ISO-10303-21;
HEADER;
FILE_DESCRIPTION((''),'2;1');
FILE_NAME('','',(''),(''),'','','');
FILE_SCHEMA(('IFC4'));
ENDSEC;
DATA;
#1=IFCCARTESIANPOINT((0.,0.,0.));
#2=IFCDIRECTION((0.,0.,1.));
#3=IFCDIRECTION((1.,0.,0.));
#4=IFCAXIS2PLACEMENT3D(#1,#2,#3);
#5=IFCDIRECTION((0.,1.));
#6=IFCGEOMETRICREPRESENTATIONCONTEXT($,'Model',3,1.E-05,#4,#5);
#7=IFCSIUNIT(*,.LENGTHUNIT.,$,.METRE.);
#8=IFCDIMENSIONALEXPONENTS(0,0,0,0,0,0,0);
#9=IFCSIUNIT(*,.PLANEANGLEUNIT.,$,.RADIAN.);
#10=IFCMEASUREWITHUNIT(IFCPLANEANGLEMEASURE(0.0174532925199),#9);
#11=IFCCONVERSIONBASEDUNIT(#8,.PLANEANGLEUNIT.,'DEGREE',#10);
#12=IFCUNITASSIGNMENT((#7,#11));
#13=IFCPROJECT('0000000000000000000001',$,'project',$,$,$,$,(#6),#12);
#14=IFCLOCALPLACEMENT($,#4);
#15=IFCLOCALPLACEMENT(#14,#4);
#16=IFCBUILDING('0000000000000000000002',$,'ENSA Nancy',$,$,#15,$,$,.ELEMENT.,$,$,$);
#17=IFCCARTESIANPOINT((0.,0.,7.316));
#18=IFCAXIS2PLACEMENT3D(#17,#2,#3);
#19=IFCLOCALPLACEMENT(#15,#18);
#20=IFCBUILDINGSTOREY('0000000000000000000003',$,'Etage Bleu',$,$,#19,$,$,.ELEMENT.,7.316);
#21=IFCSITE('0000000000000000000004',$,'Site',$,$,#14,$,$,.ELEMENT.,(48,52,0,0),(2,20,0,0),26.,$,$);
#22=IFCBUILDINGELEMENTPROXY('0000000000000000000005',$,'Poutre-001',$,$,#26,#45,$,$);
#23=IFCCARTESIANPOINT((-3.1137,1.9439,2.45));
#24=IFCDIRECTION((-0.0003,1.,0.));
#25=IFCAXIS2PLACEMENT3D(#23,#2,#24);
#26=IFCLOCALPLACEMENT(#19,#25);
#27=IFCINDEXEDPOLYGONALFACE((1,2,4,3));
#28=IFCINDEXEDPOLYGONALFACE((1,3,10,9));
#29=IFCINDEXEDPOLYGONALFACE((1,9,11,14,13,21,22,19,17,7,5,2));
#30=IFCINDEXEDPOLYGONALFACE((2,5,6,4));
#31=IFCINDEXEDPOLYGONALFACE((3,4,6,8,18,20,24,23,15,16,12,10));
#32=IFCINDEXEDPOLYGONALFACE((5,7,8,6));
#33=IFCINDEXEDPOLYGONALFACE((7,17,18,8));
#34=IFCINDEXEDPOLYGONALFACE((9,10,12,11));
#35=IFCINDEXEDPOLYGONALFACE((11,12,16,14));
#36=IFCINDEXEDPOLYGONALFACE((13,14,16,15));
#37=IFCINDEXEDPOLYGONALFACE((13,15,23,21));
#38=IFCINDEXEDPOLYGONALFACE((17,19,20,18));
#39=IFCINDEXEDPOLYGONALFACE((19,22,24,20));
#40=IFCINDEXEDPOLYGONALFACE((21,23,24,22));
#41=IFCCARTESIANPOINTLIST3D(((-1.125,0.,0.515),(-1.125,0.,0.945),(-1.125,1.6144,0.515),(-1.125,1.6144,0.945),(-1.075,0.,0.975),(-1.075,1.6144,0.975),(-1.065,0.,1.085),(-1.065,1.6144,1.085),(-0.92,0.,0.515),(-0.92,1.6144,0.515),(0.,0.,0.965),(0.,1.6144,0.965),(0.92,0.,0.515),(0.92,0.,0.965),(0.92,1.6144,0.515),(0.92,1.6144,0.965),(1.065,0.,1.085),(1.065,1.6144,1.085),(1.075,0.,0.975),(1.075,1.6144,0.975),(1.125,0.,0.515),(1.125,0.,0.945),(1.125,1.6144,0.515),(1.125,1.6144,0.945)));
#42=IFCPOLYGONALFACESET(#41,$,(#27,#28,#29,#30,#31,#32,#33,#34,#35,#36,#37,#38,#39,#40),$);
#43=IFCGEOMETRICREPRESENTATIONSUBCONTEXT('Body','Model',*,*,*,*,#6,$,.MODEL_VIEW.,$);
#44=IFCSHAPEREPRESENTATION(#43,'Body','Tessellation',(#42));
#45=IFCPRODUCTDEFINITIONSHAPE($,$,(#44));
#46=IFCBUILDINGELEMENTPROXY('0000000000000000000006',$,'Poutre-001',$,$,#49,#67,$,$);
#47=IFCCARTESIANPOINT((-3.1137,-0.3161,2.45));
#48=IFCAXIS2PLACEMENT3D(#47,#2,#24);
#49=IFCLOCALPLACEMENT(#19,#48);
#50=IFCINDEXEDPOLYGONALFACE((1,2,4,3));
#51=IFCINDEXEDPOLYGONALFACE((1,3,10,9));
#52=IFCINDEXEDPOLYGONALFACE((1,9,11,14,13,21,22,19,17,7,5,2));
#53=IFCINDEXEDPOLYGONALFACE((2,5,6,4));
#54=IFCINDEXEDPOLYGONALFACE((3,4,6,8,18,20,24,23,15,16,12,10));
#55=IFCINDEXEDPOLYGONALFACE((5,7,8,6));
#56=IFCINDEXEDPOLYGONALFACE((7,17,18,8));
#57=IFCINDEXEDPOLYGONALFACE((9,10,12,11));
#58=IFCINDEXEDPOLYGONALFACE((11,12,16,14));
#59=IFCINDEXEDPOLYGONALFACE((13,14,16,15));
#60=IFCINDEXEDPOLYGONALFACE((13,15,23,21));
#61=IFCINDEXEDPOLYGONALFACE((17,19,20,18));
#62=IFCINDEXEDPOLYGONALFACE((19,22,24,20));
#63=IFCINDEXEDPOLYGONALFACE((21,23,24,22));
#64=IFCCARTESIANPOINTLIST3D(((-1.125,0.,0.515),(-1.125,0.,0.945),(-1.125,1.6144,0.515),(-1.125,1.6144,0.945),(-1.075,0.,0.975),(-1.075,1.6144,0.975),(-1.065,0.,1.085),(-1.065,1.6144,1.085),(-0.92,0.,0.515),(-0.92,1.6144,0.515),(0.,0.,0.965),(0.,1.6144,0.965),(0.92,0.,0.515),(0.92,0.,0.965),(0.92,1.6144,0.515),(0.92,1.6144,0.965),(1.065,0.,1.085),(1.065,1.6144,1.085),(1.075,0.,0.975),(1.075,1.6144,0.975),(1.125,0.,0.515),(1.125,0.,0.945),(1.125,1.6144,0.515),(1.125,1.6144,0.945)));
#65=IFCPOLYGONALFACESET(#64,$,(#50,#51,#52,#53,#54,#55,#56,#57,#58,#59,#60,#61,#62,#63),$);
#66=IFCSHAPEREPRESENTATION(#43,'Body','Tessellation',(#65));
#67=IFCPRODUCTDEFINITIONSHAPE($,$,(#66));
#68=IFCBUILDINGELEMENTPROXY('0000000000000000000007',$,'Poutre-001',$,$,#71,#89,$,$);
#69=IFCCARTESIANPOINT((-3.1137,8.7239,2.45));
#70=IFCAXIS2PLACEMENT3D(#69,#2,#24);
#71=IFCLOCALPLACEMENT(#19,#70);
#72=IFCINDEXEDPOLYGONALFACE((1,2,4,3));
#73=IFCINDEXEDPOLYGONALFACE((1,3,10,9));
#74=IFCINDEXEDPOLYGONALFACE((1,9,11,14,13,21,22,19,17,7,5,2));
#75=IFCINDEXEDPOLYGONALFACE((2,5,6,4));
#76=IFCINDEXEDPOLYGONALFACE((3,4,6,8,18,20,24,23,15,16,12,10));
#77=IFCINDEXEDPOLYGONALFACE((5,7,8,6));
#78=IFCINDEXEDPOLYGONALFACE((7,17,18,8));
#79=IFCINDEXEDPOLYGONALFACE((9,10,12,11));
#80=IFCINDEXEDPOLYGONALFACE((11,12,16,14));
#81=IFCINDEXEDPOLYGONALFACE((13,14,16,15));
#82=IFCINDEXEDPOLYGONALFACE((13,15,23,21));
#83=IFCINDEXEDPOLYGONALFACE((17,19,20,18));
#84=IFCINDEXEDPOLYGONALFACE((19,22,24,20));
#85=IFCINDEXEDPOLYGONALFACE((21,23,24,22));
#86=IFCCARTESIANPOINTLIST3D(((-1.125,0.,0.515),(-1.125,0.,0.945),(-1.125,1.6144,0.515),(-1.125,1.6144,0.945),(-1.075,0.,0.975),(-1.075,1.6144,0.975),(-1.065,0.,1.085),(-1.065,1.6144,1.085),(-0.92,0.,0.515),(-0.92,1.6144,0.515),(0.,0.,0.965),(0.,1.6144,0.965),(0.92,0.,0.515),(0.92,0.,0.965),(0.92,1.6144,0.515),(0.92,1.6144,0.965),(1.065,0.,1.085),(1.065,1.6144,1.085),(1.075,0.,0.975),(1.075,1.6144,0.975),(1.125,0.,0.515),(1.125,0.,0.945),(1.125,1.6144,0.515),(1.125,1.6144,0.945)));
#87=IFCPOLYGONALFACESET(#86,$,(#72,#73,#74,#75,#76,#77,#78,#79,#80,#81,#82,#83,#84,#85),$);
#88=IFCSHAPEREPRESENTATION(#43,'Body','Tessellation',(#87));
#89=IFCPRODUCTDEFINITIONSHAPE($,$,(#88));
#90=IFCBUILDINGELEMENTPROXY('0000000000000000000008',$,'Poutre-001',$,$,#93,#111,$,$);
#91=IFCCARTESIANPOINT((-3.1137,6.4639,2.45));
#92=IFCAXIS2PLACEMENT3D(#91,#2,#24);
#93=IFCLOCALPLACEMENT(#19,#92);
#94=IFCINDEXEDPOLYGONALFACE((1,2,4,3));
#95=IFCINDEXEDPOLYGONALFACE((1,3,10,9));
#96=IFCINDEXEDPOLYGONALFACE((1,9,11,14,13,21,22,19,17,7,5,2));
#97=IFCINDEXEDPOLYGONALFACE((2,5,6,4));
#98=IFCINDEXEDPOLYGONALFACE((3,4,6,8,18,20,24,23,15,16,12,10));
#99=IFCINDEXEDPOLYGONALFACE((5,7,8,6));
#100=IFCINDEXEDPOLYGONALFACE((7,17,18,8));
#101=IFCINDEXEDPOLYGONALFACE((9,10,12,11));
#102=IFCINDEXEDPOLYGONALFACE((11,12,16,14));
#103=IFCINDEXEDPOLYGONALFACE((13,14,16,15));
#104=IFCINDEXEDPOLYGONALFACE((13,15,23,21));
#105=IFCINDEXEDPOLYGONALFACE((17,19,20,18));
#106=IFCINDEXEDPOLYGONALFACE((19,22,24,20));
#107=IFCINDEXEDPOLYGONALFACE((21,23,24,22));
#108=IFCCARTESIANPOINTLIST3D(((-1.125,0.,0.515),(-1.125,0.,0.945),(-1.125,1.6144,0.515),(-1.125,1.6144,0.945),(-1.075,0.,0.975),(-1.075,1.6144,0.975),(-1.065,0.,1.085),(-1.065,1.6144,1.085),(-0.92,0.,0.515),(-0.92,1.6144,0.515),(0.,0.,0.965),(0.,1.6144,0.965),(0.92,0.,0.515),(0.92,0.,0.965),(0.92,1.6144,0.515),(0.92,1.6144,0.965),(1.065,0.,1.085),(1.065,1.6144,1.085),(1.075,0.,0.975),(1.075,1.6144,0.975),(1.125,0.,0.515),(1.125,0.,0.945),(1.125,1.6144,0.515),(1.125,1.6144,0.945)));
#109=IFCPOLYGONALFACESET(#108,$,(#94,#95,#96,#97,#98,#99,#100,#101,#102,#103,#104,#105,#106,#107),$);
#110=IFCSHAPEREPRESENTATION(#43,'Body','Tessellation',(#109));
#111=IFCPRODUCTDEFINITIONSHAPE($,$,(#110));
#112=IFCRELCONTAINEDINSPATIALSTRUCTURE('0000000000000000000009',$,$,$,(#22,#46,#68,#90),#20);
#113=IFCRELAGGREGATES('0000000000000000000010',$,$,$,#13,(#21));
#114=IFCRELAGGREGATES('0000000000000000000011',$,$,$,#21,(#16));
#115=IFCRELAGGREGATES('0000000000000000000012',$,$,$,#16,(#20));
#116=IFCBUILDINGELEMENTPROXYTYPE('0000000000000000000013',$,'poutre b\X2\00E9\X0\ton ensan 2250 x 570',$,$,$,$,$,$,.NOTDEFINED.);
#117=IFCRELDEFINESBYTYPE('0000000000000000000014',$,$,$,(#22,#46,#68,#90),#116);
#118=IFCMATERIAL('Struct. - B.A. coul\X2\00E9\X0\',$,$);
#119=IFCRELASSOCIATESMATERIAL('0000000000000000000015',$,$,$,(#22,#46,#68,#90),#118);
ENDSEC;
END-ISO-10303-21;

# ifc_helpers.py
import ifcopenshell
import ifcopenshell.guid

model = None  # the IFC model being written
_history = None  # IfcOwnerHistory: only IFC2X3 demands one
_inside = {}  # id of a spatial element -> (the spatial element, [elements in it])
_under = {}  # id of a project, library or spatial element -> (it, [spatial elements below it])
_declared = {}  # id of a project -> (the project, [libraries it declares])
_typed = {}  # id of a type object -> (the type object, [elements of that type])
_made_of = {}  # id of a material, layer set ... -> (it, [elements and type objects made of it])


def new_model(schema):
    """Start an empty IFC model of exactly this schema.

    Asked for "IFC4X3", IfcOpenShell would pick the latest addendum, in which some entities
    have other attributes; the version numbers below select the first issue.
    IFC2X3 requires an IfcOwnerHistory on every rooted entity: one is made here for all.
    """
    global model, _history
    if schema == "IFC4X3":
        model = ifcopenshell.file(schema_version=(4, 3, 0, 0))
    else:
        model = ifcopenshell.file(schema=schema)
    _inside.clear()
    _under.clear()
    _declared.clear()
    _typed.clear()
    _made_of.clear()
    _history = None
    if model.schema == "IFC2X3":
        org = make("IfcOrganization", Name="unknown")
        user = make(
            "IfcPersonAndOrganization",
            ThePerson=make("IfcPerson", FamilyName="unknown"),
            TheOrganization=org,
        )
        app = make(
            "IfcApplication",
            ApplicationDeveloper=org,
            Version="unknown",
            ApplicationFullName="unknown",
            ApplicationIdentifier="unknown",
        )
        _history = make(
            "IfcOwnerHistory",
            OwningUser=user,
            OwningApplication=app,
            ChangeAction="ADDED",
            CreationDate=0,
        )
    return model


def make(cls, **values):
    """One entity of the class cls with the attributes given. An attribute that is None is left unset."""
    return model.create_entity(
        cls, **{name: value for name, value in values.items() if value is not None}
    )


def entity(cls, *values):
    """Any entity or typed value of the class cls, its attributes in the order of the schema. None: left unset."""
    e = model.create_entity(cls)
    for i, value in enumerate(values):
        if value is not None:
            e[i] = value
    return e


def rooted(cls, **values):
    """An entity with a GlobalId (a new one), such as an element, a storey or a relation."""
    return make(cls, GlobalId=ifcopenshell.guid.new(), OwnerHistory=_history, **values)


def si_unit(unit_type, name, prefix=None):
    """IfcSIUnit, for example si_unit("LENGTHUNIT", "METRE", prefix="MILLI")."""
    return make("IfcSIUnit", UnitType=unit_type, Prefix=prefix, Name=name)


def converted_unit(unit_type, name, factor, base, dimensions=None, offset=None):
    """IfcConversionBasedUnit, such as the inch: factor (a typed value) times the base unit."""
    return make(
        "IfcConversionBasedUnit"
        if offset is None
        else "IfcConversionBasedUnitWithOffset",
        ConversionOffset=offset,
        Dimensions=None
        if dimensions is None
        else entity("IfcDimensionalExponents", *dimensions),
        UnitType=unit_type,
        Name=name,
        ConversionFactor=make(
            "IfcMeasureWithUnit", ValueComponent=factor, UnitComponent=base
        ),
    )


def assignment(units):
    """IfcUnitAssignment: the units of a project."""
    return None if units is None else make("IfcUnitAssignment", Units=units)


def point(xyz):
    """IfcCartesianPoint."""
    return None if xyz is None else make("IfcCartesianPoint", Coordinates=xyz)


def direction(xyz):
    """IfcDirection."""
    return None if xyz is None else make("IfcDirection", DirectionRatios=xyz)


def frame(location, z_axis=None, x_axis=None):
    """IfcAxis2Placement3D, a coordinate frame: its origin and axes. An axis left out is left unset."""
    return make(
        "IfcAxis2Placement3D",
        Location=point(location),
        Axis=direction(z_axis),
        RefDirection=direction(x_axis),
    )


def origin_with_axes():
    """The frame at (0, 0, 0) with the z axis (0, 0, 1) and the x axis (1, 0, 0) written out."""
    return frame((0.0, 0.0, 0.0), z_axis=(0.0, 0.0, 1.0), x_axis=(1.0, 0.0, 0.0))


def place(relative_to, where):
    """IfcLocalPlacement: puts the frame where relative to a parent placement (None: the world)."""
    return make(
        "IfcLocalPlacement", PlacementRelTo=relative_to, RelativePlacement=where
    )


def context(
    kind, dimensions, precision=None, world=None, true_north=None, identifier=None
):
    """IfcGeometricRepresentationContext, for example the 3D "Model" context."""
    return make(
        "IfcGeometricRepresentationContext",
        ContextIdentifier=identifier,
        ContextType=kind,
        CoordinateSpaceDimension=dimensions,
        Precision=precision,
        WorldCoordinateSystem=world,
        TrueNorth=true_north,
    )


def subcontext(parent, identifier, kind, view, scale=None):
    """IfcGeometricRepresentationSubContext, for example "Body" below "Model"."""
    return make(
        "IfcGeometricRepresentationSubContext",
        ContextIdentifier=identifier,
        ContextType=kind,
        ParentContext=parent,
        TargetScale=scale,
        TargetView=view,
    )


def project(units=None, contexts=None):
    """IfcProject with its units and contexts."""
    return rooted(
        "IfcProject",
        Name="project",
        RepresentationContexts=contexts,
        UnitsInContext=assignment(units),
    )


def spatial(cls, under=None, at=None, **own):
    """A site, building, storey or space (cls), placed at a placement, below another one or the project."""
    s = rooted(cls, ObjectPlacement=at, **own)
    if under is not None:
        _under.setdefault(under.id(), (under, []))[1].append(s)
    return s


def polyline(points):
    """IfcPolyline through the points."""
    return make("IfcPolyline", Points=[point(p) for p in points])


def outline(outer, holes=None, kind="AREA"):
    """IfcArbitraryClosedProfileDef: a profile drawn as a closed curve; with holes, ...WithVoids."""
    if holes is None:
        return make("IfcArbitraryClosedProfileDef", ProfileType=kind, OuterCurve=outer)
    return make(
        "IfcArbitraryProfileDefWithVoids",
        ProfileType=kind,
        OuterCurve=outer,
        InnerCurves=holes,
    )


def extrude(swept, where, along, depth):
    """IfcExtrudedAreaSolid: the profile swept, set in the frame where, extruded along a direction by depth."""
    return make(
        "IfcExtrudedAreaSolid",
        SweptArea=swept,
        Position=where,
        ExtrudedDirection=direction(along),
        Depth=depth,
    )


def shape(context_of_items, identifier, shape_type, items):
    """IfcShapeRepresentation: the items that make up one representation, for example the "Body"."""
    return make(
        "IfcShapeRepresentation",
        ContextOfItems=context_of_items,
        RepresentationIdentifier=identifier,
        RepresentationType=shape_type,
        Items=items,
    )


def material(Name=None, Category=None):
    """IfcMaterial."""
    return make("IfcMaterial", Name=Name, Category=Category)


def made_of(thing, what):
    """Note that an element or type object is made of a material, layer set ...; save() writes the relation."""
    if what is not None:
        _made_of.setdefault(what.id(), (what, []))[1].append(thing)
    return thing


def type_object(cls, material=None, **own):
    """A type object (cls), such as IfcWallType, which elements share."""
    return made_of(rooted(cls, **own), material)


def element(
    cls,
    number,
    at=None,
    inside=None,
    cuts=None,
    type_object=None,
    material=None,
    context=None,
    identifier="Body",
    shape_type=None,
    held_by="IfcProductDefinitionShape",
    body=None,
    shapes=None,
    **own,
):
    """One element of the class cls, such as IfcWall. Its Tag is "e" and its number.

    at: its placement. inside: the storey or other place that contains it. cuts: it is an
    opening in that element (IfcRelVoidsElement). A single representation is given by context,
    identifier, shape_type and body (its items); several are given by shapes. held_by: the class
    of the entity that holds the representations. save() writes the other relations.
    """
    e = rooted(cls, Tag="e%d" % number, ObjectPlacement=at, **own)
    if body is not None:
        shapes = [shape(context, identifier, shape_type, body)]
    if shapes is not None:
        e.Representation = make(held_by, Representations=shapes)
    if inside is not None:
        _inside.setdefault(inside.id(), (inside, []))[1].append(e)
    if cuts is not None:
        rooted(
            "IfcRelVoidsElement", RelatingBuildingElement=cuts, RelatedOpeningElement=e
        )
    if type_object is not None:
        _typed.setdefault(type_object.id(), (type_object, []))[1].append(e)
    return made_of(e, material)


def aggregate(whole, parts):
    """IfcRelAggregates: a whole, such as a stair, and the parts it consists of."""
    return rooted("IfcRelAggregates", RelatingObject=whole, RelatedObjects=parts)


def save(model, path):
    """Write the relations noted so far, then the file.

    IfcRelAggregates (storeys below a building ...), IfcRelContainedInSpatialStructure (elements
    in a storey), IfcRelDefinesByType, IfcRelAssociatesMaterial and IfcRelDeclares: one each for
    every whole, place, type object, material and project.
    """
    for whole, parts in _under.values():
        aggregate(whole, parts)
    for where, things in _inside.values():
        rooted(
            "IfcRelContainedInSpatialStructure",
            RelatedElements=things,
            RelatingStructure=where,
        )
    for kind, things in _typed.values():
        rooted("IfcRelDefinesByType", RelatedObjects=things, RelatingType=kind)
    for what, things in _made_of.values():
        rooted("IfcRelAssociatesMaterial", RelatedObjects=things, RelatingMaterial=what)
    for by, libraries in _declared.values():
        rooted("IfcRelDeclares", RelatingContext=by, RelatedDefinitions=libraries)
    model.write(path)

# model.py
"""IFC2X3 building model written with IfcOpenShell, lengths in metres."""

from ifc_helpers import new_model, entity, si_unit, converted_unit, direction, frame, origin_with_axes, place, context, subcontext, project, spatial, polyline, outline, extrude, material, type_object, element, save


model = new_model("IFC2X3")

# Units and contexts
model_context = context("Model", 3, precision=1e-05, world=origin_with_axes(), true_north=direction((0.0, 1.0)))
body_context = subcontext(model_context, "Body", "Model", "MODEL_VIEW")
ifc_project = project(units=[si_unit("LENGTHUNIT", "METRE"), converted_unit("PLANEANGLEUNIT", "DEGREE", entity("IfcPlaneAngleMeasure", 0.0174532925199), si_unit("PLANEANGLEUNIT", "RADIAN"), dimensions=[0, 0, 0, 0, 0, 0, 0])], contexts=[model_context])

# Site, building, storey
site_placement = place(None, origin_with_axes())
site = spatial("IfcSite", under=ifc_project, at=site_placement, Name="Site", CompositionType="ELEMENT", RefLatitude=(48, 52, 0, 0), RefLongitude=(2, 20, 0, 0), RefElevation=26.0)
building_placement = place(site_placement, origin_with_axes())
building = spatial("IfcBuilding", under=site, at=building_placement, Name="ENSA Nancy", CompositionType="ELEMENT")
storey_placement = place(building_placement, frame((0.0, 0.0, 7.316), z_axis=(0.0, 0.0, 1.0), x_axis=(1.0, 0.0, 0.0)))
storey = spatial("IfcBuildingStorey", under=building, at=storey_placement, Name="Etage Bleu", CompositionType="ELEMENT", Elevation=7.316)

# Building element proxies
ifc_material_1 = material(Name="Struct. - B.A. coulé")
building_element_proxy_type_1 = type_object("IfcBuildingElementProxyType", Name="poutre béton ensan 2250 x 570", PredefinedType="NOTDEFINED")
for number, where, z_axis, x_axis, name in (
    (1, (-3.1137, 1.9439, 2.45), (0.0, 0.0, 1.0), (-0.0003, 1.0, 0.0), "Poutre-001"),
    (2, (-3.1137, -0.3161, 2.45), (0.0, 0.0, 1.0), (-0.0003, 1.0, 0.0), "Poutre-001"),
    (3, (-3.1137, 8.7239, 2.45), (0.0, 0.0, 1.0), (-0.0003, 1.0, 0.0), "Poutre-001"),
    (4, (-3.1137, 6.4639, 2.45), (0.0, 0.0, 1.0), (-0.0003, 1.0, 0.0), "Poutre-001"),
):
    element("IfcBuildingElementProxy", number, at=place(storey_placement, frame(where, z_axis=z_axis, x_axis=x_axis)), inside=storey, type_object=building_element_proxy_type_1, material=ifc_material_1, Name=name, context=body_context, shape_type="SweptSolid", body=[
        extrude(outline(polyline([(-1.065, 1.085), (-1.075, 0.975), (-1.125, 0.945), (-1.125, 0.515), (-0.92, 0.515), (0.0, 0.965), (0.92, 0.965), (0.92, 0.515), (1.125, 0.515), (1.125, 0.945), (1.075, 0.975), (1.065, 1.085), (-1.065, 1.085)])), frame((0.0, 1.6144, 0.0), z_axis=(0.0, -1.0, 0.0), x_axis=(1.0, 0.0, 0.0)), (0.0, 0.0, 1.0), 1.6144),
    ])

save(model, "model.ifc")
